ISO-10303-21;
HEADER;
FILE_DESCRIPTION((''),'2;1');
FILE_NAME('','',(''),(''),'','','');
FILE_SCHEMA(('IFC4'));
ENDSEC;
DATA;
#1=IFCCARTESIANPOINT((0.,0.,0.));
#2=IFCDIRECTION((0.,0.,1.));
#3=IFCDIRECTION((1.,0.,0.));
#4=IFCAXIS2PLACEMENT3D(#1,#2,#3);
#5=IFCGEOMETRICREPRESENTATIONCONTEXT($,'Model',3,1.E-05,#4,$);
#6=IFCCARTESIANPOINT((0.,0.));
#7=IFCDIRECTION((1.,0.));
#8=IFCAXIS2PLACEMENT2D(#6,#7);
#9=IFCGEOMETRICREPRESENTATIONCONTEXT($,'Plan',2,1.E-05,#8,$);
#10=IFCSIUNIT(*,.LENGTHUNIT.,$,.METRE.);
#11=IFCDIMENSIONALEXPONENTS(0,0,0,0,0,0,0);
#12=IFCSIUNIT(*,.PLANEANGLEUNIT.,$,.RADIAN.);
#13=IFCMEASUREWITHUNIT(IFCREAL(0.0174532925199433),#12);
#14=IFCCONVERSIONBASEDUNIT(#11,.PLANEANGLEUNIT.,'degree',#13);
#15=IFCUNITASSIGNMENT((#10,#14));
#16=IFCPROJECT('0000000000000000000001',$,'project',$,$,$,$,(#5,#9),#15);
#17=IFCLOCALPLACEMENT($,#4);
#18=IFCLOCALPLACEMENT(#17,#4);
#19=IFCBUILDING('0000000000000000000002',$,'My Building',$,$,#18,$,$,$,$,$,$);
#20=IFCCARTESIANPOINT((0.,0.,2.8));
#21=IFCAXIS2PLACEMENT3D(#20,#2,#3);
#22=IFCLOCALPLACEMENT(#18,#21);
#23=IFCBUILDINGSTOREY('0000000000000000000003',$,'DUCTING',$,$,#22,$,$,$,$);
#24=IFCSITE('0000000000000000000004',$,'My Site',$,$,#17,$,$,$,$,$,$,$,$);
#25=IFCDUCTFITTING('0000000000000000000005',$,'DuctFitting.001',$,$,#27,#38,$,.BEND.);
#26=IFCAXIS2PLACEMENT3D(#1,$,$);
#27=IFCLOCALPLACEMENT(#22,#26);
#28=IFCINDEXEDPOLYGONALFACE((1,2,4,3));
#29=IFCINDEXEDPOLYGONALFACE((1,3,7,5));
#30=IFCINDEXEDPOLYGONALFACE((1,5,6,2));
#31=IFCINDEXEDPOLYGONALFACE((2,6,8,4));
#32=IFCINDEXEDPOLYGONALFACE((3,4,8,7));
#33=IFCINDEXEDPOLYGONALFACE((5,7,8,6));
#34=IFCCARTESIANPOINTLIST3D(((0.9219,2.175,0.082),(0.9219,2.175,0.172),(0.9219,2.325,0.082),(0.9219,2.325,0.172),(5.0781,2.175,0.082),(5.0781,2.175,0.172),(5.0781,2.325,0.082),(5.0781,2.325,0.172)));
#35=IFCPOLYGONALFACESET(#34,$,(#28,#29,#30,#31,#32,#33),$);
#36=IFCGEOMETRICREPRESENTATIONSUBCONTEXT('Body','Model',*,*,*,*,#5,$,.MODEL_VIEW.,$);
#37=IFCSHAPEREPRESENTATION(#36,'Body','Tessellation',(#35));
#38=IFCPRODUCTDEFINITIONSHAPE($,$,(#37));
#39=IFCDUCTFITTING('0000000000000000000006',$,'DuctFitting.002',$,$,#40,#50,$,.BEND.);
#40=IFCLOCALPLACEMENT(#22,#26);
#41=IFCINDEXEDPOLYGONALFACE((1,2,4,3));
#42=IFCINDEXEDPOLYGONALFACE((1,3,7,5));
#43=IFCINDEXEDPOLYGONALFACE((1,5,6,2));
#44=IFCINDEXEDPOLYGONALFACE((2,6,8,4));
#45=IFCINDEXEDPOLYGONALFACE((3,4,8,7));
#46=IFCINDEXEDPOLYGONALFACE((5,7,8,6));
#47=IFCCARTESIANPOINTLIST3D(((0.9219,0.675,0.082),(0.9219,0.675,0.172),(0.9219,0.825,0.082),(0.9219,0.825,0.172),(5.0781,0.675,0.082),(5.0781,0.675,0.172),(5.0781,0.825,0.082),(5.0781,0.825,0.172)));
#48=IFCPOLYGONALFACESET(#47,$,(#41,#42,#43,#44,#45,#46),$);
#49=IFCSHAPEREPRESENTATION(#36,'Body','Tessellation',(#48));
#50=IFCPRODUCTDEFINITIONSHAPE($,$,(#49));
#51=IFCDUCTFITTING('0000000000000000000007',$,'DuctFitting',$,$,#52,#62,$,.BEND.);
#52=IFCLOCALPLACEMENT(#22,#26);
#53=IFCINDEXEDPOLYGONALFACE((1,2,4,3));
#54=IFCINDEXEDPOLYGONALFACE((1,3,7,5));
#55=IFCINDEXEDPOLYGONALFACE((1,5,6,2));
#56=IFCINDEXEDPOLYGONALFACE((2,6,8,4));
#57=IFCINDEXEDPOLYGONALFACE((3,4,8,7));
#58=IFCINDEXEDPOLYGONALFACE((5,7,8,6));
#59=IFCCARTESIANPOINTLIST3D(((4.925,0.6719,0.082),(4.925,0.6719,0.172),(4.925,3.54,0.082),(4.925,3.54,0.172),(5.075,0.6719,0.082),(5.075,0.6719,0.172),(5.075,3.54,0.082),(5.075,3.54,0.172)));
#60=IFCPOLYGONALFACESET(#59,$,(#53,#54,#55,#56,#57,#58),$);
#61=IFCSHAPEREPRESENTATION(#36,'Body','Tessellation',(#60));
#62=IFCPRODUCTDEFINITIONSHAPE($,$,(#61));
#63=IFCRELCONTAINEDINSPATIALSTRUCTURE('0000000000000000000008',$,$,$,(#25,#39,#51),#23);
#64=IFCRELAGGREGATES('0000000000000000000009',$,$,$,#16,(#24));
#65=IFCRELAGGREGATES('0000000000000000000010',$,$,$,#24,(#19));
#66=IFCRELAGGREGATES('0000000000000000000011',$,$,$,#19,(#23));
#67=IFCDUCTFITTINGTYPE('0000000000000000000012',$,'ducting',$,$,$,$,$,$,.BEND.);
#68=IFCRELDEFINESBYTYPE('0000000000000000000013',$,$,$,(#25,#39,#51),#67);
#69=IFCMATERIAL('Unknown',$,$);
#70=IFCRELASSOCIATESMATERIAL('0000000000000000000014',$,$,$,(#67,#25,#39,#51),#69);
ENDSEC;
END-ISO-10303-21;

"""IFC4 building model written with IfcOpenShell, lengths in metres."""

from ifc_helpers import new_model, entity, si_unit, converted_unit, frame, origin_with_axes, origin_2d_with_axis, place, context, subcontext, project, spatial, rectangle, extrude, material, material_profile, profile_set, profile_usage, type_object, element, save


model = new_model("IFC4")

# Units and contexts
model_context = context("Model", 3, precision=1e-05, world=origin_with_axes())
plan_context = context("Plan", 2, precision=1e-05, world=origin_2d_with_axis())
body_context = subcontext(model_context, "Body", "Model", "MODEL_VIEW")
ifc_project = project(units=[si_unit("LENGTHUNIT", "METRE"), converted_unit("PLANEANGLEUNIT", "degree", entity("IfcReal", 0.0174532925199433), si_unit("PLANEANGLEUNIT", "RADIAN"), dimensions=[0, 0, 0, 0, 0, 0, 0])], contexts=[model_context, plan_context])

# Site, building, storey
site_placement = place(None, origin_with_axes())
site = spatial("IfcSite", under=ifc_project, at=site_placement, Name="My Site")
building_placement = place(site_placement, origin_with_axes())
building = spatial("IfcBuilding", under=site, at=building_placement, Name="My Building")
storey_placement = place(building_placement, frame((0.0, 0.0, 2.8), z_axis=(0.0, 0.0, 1.0), x_axis=(1.0, 0.0, 0.0)))
storey = spatial("IfcBuildingStorey", under=building, at=storey_placement, Name="DUCTING")

# Duct fittings
ifc_material = material(Name="Unknown")
ifc_material_profile = material_profile(ifc_material, rectangle(XDim=0.15, YDim=0.09))
ifc_profile_set = profile_set([ifc_material_profile])
ifc_profile_usage_1 = profile_usage(ifc_profile_set, cardinal=5)
duct_fitting_type = type_object("IfcDuctFittingType", Name="ducting", PredefinedType="BEND", material=ifc_profile_set)
duct_fitting_1_placement = place(storey_placement, frame((0.9219, 2.25, 0.127), z_axis=(1.0, 0.0, 0.0), x_axis=(0.0, 1.0, 0.0)))
element("IfcDuctFitting", 1, at=duct_fitting_1_placement, inside=storey, type_object=duct_fitting_type, material=ifc_profile_usage_1, Name="DuctFitting.001", PredefinedType="BEND", context=body_context, shape_type="SweptSolid", body=[
    extrude(rectangle(XDim=0.15, YDim=0.09), origin_with_axes(), (0.0, 0.0, 1.0), 4.1561),
])
ifc_profile_usage_2 = profile_usage(ifc_profile_set, cardinal=5)
duct_fitting_2_placement = place(storey_placement, frame((0.9219, 0.75, 0.127), z_axis=(1.0, 0.0, 0.0), x_axis=(0.0, 1.0, 0.0)))
element("IfcDuctFitting", 2, at=duct_fitting_2_placement, inside=storey, type_object=duct_fitting_type, material=ifc_profile_usage_2, Name="DuctFitting.002", PredefinedType="BEND", context=body_context, shape_type="SweptSolid", body=[
    extrude(rectangle(XDim=0.15, YDim=0.09), origin_with_axes(), (0.0, 0.0, 1.0), 4.1561),
])
ifc_profile_usage_3 = profile_usage(ifc_profile_set, cardinal=5)
duct_fitting_3_placement = place(storey_placement, frame((5.0, 0.6719, 0.127), z_axis=(0.0, 1.0, 0.0), x_axis=(-1.0, 0.0, 0.0)))
element("IfcDuctFitting", 3, at=duct_fitting_3_placement, inside=storey, type_object=duct_fitting_type, material=ifc_profile_usage_3, Name="DuctFitting", PredefinedType="BEND", context=body_context, shape_type="SweptSolid", body=[
    extrude(rectangle(XDim=0.15, YDim=0.09), origin_with_axes(), (0.0, 0.0, 1.0), 2.868),
])

save(model, "model.ifc")
